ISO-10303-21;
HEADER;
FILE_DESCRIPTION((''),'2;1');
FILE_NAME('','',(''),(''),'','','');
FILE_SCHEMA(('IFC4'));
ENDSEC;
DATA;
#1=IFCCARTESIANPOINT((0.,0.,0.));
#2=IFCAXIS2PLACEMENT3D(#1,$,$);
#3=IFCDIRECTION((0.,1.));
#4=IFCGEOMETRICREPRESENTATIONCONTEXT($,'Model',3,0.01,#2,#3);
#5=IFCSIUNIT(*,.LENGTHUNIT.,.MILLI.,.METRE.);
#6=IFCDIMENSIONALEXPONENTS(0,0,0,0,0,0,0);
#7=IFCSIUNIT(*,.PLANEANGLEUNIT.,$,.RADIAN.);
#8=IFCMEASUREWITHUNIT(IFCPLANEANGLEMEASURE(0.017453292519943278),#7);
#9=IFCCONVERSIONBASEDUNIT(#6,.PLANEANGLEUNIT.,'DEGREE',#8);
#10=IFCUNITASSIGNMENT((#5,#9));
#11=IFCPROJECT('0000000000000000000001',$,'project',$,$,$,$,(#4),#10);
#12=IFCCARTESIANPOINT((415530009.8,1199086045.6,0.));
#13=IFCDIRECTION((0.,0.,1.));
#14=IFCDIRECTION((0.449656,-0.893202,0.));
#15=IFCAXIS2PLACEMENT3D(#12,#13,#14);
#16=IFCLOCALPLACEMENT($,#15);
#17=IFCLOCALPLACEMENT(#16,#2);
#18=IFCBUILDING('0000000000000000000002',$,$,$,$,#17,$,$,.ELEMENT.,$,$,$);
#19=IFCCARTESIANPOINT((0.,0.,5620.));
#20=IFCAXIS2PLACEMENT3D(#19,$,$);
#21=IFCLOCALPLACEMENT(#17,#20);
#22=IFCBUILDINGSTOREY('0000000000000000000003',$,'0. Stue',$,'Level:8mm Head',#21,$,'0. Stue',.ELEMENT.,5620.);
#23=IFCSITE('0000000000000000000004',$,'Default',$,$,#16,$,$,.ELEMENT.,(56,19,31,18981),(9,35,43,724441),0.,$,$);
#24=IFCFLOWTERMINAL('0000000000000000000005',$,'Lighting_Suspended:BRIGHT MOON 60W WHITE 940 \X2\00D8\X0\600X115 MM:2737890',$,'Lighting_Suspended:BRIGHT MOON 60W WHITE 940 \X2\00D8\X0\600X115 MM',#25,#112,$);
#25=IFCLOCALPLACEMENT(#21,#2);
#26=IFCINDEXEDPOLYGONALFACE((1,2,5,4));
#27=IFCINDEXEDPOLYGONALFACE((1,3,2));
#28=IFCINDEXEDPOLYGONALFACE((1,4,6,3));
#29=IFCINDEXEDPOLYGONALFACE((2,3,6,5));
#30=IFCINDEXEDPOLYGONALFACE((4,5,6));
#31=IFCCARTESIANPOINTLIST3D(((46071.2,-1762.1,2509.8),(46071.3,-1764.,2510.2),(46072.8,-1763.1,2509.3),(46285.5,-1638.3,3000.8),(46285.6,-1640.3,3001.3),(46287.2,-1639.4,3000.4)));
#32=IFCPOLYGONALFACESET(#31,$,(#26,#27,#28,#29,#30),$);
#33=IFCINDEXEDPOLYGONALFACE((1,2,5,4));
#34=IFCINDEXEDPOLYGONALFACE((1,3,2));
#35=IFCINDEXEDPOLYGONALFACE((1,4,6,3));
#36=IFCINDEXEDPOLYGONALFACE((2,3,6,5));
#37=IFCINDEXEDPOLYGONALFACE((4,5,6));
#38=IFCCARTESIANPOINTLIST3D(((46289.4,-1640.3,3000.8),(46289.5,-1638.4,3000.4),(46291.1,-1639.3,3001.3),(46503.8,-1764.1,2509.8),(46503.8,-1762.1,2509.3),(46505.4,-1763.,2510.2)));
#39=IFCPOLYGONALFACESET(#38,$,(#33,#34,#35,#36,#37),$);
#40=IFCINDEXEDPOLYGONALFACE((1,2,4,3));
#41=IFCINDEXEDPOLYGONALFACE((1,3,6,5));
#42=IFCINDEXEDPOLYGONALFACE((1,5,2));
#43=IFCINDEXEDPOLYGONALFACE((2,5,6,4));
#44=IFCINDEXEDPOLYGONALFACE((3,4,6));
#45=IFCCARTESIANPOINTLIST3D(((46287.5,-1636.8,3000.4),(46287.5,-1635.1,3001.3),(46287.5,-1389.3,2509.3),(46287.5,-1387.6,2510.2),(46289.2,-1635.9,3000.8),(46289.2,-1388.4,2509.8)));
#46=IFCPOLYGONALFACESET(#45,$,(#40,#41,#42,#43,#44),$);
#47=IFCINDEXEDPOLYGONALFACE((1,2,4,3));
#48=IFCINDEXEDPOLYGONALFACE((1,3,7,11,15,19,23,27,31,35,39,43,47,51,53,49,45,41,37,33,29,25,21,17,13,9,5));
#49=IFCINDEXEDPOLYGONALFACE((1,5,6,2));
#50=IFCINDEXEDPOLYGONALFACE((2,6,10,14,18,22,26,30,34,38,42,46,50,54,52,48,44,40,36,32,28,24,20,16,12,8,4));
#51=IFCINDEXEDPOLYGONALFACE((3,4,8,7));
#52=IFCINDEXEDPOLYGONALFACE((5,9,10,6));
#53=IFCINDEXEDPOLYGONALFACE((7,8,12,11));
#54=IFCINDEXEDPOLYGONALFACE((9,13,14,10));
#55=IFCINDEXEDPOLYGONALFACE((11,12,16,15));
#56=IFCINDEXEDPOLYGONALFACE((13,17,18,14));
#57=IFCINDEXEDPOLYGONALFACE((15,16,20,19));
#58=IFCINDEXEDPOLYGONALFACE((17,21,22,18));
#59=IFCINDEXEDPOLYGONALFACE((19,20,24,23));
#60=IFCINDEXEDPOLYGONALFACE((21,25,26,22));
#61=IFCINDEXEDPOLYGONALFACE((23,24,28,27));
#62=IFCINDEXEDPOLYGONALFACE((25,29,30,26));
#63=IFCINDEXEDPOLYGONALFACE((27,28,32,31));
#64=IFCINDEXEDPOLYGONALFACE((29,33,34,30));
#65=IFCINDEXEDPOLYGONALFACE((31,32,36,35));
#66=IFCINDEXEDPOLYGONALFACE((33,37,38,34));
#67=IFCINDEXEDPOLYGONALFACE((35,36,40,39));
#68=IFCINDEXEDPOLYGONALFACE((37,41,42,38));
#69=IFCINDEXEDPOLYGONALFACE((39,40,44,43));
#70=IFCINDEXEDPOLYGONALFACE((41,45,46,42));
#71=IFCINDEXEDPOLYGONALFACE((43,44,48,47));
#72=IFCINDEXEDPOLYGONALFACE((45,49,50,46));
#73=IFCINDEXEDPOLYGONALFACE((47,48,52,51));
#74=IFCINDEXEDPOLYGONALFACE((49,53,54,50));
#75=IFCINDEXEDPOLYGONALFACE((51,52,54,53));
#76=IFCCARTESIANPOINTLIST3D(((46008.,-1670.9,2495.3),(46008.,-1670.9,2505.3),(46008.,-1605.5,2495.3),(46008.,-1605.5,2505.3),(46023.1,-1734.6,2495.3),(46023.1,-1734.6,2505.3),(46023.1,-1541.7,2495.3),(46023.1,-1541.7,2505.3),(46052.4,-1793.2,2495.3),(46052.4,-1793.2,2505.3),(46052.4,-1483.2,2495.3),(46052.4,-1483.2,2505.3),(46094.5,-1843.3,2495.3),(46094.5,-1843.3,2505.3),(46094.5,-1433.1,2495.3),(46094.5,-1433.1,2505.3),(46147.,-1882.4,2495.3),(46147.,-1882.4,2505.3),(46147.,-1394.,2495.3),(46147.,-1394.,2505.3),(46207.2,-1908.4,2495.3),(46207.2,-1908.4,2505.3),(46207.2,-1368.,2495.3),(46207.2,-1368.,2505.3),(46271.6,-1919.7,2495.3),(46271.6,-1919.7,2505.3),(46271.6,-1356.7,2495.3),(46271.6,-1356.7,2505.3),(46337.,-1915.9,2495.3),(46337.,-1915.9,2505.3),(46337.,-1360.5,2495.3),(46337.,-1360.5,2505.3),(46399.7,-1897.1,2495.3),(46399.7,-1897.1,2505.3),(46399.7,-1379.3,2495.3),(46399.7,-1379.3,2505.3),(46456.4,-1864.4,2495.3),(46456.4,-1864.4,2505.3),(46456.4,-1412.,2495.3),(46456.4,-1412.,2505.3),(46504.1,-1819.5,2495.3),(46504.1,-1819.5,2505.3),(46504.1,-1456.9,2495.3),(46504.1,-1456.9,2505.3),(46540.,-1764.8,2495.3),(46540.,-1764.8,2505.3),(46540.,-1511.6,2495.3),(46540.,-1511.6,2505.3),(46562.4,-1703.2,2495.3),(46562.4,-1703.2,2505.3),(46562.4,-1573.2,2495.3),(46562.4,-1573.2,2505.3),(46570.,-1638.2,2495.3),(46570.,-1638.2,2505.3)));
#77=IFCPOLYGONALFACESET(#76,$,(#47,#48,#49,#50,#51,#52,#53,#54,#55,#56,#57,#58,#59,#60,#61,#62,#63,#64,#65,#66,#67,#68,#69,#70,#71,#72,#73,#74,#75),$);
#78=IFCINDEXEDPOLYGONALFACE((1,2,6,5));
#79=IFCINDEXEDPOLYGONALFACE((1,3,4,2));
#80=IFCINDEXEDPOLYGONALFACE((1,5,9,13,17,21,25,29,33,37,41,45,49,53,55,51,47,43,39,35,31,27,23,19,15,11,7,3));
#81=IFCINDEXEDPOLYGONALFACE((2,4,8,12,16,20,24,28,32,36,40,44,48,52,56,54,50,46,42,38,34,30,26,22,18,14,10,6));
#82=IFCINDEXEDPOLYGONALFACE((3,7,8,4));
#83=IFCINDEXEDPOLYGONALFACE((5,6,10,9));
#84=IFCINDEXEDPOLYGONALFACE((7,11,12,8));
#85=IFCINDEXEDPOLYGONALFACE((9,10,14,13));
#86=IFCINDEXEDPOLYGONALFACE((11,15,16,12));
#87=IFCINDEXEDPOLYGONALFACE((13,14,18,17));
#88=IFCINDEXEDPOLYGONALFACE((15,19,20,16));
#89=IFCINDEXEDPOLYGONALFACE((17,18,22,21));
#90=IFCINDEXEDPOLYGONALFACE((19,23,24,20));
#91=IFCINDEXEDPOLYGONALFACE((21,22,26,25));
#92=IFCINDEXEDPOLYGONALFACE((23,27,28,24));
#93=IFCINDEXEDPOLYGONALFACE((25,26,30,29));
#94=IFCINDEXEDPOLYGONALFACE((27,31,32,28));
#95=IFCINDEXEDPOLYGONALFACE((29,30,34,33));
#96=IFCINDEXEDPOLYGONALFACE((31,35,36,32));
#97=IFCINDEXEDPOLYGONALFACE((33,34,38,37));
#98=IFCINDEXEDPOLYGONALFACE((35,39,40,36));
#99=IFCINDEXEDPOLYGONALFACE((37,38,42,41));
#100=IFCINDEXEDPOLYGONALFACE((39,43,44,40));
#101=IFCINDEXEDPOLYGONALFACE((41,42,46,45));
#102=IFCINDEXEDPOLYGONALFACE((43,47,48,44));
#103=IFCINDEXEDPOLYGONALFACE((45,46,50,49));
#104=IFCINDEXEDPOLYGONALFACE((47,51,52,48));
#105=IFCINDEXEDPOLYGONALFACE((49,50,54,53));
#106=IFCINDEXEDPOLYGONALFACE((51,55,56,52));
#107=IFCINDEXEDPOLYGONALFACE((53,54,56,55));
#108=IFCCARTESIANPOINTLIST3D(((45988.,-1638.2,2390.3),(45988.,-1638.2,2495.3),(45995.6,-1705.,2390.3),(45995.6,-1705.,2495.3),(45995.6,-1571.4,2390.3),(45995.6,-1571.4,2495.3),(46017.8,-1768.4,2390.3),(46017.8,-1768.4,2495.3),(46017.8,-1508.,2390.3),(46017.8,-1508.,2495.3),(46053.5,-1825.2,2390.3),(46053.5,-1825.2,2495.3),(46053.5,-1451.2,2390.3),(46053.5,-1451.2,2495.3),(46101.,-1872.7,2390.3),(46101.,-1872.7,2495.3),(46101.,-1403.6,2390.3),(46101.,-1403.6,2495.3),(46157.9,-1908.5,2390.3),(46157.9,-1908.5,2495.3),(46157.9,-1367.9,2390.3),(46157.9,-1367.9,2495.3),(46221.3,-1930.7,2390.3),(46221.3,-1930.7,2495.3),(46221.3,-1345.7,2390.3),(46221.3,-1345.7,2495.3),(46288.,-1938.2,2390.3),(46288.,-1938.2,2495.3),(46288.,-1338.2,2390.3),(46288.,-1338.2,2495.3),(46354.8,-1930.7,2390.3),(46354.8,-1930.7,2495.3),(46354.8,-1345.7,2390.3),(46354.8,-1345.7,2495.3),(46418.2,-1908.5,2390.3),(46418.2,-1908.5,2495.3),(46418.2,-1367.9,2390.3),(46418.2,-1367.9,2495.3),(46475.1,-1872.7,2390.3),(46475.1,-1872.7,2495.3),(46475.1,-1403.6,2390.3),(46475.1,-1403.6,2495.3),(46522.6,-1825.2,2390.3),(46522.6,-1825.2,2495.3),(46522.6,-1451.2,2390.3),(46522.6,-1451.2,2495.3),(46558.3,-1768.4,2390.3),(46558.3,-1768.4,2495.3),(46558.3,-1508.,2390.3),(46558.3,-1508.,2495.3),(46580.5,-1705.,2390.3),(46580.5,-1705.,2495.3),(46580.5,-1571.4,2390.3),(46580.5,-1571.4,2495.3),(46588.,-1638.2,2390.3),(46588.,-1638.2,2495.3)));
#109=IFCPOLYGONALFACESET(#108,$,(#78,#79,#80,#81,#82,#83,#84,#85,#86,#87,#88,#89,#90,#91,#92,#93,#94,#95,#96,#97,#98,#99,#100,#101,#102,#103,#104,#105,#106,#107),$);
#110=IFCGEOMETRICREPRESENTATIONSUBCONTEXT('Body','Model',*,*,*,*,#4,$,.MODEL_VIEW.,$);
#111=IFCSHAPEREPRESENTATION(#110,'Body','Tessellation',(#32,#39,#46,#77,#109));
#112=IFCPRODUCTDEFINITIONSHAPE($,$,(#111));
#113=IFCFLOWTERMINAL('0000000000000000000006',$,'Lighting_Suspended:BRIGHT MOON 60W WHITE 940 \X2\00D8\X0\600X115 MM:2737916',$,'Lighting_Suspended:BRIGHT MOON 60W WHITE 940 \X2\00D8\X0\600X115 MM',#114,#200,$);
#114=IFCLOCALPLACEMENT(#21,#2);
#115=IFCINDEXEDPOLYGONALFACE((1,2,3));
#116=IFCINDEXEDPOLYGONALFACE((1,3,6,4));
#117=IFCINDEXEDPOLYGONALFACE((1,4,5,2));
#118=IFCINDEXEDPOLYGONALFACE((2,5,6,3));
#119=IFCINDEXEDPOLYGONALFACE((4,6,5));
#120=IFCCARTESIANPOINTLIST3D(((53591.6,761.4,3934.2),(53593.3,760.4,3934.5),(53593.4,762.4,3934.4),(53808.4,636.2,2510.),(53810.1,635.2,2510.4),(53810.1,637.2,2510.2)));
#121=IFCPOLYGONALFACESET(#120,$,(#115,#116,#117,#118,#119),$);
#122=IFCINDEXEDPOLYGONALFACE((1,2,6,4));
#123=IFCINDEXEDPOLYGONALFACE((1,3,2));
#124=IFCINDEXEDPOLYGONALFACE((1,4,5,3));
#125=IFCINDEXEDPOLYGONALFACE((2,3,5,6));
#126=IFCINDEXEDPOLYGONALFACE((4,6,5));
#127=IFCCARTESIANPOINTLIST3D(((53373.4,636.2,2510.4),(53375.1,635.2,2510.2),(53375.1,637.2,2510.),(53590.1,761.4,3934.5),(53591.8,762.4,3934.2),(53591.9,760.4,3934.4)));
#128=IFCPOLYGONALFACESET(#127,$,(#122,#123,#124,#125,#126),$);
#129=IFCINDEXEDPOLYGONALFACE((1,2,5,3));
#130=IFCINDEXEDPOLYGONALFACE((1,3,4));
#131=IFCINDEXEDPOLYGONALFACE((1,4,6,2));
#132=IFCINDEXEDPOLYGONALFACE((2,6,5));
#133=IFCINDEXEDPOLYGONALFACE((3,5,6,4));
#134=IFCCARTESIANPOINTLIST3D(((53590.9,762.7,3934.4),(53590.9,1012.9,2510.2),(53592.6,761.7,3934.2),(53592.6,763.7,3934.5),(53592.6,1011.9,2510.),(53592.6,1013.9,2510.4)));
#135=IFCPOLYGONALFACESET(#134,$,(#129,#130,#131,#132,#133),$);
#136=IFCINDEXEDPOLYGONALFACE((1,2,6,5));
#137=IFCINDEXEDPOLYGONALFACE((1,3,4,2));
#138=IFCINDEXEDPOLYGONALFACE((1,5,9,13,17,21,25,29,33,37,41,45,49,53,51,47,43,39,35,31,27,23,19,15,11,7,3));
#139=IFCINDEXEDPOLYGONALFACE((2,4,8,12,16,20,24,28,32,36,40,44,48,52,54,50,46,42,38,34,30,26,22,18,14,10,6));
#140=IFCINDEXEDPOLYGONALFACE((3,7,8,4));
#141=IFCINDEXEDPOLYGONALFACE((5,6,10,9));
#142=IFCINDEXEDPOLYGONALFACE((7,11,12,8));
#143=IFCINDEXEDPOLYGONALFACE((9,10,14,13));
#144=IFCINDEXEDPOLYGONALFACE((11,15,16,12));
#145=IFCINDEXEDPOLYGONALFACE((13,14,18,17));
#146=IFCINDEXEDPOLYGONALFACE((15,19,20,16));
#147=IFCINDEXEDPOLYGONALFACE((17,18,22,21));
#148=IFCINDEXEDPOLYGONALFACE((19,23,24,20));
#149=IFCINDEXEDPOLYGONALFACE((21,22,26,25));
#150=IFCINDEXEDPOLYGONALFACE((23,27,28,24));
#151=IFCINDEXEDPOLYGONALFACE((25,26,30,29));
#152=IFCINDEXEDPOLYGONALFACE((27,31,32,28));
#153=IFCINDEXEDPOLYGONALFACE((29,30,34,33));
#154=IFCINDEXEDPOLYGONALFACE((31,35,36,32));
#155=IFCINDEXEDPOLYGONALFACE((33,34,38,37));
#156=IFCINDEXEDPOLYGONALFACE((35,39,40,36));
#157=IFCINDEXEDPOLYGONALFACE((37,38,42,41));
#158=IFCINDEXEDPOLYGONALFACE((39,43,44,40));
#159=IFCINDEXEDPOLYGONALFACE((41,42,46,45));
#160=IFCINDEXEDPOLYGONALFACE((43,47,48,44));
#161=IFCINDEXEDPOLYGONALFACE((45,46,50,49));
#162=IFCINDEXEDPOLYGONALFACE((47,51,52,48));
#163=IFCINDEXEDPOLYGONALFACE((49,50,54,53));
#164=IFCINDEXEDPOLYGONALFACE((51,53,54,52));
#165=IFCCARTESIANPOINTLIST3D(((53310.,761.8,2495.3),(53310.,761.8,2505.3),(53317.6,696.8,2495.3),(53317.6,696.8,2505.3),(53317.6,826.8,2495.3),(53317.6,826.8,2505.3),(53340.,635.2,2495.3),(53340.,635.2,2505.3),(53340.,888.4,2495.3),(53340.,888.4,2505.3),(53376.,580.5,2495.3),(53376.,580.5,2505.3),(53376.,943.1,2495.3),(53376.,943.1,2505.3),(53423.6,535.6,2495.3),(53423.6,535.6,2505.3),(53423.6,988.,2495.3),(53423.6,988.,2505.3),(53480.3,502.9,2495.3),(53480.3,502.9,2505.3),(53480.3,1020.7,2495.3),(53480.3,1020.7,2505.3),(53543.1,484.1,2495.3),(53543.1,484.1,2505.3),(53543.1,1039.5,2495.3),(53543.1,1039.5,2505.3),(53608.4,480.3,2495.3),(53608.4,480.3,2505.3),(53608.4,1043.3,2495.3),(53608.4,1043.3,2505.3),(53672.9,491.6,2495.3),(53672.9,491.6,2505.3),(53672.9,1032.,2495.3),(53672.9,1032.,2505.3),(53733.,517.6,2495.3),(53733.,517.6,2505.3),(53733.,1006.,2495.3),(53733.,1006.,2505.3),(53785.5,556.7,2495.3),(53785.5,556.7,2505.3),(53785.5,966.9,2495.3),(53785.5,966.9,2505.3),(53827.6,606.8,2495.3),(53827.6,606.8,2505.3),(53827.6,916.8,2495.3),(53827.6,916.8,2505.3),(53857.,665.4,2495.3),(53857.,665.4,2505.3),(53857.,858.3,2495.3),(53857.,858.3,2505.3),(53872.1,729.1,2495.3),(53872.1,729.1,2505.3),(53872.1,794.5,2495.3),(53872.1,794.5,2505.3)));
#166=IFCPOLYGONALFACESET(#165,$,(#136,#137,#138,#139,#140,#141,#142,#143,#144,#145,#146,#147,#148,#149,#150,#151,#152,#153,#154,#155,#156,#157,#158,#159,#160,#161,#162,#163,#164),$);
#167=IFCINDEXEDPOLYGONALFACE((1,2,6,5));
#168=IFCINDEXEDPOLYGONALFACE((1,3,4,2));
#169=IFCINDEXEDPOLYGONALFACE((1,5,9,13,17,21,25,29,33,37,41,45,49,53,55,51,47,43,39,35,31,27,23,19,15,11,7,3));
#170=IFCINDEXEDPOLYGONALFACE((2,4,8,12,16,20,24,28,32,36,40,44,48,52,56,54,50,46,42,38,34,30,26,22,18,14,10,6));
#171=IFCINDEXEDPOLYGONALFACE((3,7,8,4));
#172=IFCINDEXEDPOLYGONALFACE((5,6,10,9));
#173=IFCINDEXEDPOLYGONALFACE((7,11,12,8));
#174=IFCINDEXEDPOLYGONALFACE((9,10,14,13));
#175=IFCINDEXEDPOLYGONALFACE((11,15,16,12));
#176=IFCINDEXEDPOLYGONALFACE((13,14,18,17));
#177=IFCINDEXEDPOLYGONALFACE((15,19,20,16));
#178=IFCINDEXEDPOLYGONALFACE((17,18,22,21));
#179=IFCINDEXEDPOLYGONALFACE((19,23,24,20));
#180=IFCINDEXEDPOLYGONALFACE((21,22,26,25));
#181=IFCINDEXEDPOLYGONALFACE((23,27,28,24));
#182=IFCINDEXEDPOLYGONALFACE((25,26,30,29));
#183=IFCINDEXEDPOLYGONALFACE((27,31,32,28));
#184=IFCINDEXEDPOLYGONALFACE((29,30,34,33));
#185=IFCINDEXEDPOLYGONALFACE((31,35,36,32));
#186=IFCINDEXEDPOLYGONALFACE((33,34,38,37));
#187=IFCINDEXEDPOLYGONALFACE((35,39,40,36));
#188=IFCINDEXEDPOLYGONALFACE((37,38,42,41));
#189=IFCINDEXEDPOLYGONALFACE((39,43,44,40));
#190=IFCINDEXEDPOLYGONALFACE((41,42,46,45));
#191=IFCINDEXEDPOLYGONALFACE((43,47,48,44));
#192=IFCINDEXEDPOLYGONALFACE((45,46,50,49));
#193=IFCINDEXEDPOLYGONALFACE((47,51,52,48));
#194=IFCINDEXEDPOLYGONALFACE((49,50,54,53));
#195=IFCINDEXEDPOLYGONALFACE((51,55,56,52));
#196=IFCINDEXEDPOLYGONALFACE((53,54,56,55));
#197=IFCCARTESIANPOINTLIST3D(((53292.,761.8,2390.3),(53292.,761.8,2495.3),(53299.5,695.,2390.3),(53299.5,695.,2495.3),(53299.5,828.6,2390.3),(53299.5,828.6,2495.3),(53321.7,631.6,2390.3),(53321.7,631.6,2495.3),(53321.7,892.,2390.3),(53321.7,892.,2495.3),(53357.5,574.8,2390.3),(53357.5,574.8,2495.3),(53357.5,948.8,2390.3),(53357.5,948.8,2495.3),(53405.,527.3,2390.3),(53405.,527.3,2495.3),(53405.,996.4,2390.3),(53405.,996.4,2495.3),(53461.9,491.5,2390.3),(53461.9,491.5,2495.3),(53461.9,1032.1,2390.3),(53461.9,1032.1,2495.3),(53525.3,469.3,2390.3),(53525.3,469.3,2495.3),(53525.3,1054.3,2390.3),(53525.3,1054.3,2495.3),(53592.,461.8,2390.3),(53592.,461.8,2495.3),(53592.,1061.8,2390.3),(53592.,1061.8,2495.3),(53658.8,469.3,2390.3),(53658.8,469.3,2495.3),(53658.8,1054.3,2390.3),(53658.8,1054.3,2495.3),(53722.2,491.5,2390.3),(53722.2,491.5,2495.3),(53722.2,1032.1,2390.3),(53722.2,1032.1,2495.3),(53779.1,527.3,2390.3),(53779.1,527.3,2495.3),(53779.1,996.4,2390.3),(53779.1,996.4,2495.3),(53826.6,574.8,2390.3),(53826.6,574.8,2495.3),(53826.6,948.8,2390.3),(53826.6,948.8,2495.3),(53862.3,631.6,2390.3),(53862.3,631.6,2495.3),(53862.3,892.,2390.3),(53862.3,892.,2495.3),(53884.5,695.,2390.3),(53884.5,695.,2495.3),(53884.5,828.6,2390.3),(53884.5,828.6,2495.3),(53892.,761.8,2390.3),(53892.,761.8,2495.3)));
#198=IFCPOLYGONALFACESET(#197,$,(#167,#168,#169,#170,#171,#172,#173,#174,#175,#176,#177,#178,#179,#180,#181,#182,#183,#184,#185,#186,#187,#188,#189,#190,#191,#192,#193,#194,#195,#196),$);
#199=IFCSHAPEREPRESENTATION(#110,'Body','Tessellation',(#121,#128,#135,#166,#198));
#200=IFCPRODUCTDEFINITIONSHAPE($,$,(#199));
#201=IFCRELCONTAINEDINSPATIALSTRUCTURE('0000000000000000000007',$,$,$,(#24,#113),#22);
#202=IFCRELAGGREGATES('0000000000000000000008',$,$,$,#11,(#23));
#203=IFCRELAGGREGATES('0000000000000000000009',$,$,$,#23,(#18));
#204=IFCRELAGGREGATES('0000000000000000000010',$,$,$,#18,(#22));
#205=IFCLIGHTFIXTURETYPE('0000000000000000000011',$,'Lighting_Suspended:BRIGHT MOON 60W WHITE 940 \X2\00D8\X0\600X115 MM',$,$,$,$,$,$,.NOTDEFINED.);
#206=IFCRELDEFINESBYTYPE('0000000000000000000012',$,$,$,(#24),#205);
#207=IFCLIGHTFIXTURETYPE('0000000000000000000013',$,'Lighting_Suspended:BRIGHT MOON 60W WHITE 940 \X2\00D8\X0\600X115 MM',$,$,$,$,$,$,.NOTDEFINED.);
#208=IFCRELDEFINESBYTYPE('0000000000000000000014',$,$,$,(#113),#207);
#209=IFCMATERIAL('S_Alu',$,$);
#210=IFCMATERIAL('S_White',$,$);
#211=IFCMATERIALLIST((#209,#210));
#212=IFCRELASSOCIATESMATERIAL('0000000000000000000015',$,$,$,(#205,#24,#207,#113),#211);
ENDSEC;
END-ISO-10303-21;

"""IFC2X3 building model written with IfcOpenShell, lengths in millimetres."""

from ifc_helpers import new_model, entity, si_unit, converted_unit, direction, frame, frame_2d, origin, place, context, subcontext, project, spatial, polyline, circle, outline, extrude, source, transform, mapped, material, material_list, type_object, type_shapes, element, save


model = new_model("IFC2X3")

# Units and contexts
model_context = context("Model", 3, precision=0.01, world=origin(), true_north=direction((0.0, 1.0)))
body_context = subcontext(model_context, "Body", "Model", "MODEL_VIEW")
ifc_project = project(units=[si_unit("LENGTHUNIT", "METRE", prefix="MILLI"), converted_unit("PLANEANGLEUNIT", "DEGREE", entity("IfcPlaneAngleMeasure", 0.017453292519943278), si_unit("PLANEANGLEUNIT", "RADIAN"), dimensions=[0, 0, 0, 0, 0, 0, 0])], contexts=[model_context])

# Site, building, storey
site_placement = place(None, frame((415530009.8, 1199086045.6, 0.0), z_axis=(0.0, 0.0, 1.0), x_axis=(0.449656, -0.893202, 0.0)))
site = spatial("IfcSite", under=ifc_project, at=site_placement, Name="Default", CompositionType="ELEMENT", RefLatitude=(56, 19, 31, 18981), RefLongitude=(9, 35, 43, 724441), RefElevation=0.0)
building_placement = place(site_placement, origin())
building = spatial("IfcBuilding", under=site, at=building_placement, CompositionType="ELEMENT")
storey_placement = place(building_placement, frame((0.0, 0.0, 5620.0)))
storey = spatial("IfcBuildingStorey", under=building, at=storey_placement, Name="0. Stue", ObjectType="Level:8mm Head", LongName="0. Stue", CompositionType="ELEMENT", Elevation=5620.0)

# Flow terminals
ifc_material_1 = material(Name="S_White")
ifc_material_2 = material(Name="S_Alu")
ifc_material_list = material_list([ifc_material_2, ifc_material_1])
light_fixture_type_1 = type_object("IfcLightFixtureType", Name="Lighting_Suspended:BRIGHT MOON 60W WHITE 940 Ø600X115 MM", PredefinedType="NOTDEFINED", material=ifc_material_list)
shared_shape_1 = source(origin(), body_context, "Body", "SweptSolid", [
    extrude(outline(polyline([(-1.0, -0.6), (1.0, -0.6), (0.0, 1.2), (-1.0, -0.6)])), frame((-216.3, -124.9, -495.5), z_axis=(0.389771, 0.225034, 0.892994), x_axis=(-0.81969, 0.526752, 0.225034)), (0.0, 0.0, 1.0), 549.9),
    extrude(outline(polyline([(-1.0, -0.6), (1.0, -0.6), (0.0, 1.2), (-1.0, -0.6)])), frame((216.3, -124.9, -495.5), z_axis=(-0.389771, 0.225034, 0.892994), x_axis=(-0.046335, -0.973248, 0.225034)), (0.0, 0.0, 1.0), 549.9),
    extrude(outline(polyline([(-1.0, -0.6), (1.0, -0.6), (0.0, 1.2), (-1.0, -0.6)])), frame((0.0, 249.7, -495.5), z_axis=(0.0, -0.450069, 0.892994), x_axis=(0.866025, 0.446497, 0.225034)), (0.0, 0.0, 1.0), 549.9),
    extrude(circle(Radius=282.0, at=frame_2d((0.0, 0.0), x_axis=(1.0, 0.0))), frame((0.0, 0.0, -510.0)), (0.0, 0.0, 1.0), 10.0),
    extrude(circle(Radius=300.0, at=frame_2d((0.0, 0.0), x_axis=(1.0, 0.0))), frame((0.0, 0.0, -615.0)), (0.0, 0.0, 1.0), 105.0),
])
type_shapes(light_fixture_type_1, [shared_shape_1])
for number, where, name in (
    (1, (46288.0, -1638.2, 3005.3), "Lighting_Suspended:BRIGHT MOON 60W WHITE 940 Ø600X115 MM:2737890"),
):
    element("IfcFlowTerminal", number, at=place(storey_placement, frame(where)), inside=storey, type_object=light_fixture_type_1, material=ifc_material_list, Name=name, ObjectType="Lighting_Suspended:BRIGHT MOON 60W WHITE 940 Ø600X115 MM", context=body_context, shape_type="MappedRepresentation", body=[
        mapped(shared_shape_1, transform((0.0, 0.0, 0.0), scale=1.0)),
    ])
light_fixture_type_2 = type_object("IfcLightFixtureType", Name="Lighting_Suspended:BRIGHT MOON 60W WHITE 940 Ø600X115 MM", PredefinedType="NOTDEFINED", material=ifc_material_list)
shared_shape_2 = source(origin(), body_context, "Body", "SweptSolid", [
    extrude(outline(polyline([(-1.0, -0.6), (1.0, -0.6), (0.0, 1.2), (-1.0, -0.6)])), frame((-217.5, 125.6, -1429.1), z_axis=(0.149892, -0.08654, 0.984908), x_axis=(-0.852955, 0.492454, 0.17308)), (0.0, 0.0, 1.0), 1446.0),
    extrude(outline(polyline([(-1.0, -0.6), (1.0, -0.6), (0.0, 1.2), (-1.0, -0.6)])), frame((217.5, 125.6, -1429.1), z_axis=(-0.149892, -0.08654, 0.984908), x_axis=(0.852955, 0.492454, 0.17308)), (0.0, 0.0, 1.0), 1446.0),
    extrude(outline(polyline([(-1.0, -0.6), (1.0, -0.6), (0.0, 1.2), (-1.0, -0.6)])), frame((0.0, -251.1, -1429.1), z_axis=(0.0, 0.17308, 0.984908), x_axis=(0.0, -0.984908, 0.17308)), (0.0, 0.0, 1.0), 1446.0),
    extrude(circle(Radius=282.0, at=frame_2d((0.0, 0.0), x_axis=(1.0, 0.0))), frame((0.0, 0.0, -1444.0)), (0.0, 0.0, 1.0), 10.0),
    extrude(circle(Radius=300.0, at=frame_2d((0.0, 0.0), x_axis=(1.0, 0.0))), frame((0.0, 0.0, -1549.0)), (0.0, 0.0, 1.0), 105.0),
])
type_shapes(light_fixture_type_2, [shared_shape_2])
for number, where, z_axis, x_axis, name in (
    (2, (53592.0, 761.8, 3939.3), (0.0, 0.0, 1.0), (-1.0, 0.0, 0.0), "Lighting_Suspended:BRIGHT MOON 60W WHITE 940 Ø600X115 MM:2737916"),
):
    element("IfcFlowTerminal", number, at=place(storey_placement, frame(where, z_axis=z_axis, x_axis=x_axis)), inside=storey, type_object=light_fixture_type_2, material=ifc_material_list, Name=name, ObjectType="Lighting_Suspended:BRIGHT MOON 60W WHITE 940 Ø600X115 MM", context=body_context, shape_type="MappedRepresentation", body=[
        mapped(shared_shape_2, transform((0.0, 0.0, 0.0), scale=1.0)),
    ])

save(model, "model.ifc")
